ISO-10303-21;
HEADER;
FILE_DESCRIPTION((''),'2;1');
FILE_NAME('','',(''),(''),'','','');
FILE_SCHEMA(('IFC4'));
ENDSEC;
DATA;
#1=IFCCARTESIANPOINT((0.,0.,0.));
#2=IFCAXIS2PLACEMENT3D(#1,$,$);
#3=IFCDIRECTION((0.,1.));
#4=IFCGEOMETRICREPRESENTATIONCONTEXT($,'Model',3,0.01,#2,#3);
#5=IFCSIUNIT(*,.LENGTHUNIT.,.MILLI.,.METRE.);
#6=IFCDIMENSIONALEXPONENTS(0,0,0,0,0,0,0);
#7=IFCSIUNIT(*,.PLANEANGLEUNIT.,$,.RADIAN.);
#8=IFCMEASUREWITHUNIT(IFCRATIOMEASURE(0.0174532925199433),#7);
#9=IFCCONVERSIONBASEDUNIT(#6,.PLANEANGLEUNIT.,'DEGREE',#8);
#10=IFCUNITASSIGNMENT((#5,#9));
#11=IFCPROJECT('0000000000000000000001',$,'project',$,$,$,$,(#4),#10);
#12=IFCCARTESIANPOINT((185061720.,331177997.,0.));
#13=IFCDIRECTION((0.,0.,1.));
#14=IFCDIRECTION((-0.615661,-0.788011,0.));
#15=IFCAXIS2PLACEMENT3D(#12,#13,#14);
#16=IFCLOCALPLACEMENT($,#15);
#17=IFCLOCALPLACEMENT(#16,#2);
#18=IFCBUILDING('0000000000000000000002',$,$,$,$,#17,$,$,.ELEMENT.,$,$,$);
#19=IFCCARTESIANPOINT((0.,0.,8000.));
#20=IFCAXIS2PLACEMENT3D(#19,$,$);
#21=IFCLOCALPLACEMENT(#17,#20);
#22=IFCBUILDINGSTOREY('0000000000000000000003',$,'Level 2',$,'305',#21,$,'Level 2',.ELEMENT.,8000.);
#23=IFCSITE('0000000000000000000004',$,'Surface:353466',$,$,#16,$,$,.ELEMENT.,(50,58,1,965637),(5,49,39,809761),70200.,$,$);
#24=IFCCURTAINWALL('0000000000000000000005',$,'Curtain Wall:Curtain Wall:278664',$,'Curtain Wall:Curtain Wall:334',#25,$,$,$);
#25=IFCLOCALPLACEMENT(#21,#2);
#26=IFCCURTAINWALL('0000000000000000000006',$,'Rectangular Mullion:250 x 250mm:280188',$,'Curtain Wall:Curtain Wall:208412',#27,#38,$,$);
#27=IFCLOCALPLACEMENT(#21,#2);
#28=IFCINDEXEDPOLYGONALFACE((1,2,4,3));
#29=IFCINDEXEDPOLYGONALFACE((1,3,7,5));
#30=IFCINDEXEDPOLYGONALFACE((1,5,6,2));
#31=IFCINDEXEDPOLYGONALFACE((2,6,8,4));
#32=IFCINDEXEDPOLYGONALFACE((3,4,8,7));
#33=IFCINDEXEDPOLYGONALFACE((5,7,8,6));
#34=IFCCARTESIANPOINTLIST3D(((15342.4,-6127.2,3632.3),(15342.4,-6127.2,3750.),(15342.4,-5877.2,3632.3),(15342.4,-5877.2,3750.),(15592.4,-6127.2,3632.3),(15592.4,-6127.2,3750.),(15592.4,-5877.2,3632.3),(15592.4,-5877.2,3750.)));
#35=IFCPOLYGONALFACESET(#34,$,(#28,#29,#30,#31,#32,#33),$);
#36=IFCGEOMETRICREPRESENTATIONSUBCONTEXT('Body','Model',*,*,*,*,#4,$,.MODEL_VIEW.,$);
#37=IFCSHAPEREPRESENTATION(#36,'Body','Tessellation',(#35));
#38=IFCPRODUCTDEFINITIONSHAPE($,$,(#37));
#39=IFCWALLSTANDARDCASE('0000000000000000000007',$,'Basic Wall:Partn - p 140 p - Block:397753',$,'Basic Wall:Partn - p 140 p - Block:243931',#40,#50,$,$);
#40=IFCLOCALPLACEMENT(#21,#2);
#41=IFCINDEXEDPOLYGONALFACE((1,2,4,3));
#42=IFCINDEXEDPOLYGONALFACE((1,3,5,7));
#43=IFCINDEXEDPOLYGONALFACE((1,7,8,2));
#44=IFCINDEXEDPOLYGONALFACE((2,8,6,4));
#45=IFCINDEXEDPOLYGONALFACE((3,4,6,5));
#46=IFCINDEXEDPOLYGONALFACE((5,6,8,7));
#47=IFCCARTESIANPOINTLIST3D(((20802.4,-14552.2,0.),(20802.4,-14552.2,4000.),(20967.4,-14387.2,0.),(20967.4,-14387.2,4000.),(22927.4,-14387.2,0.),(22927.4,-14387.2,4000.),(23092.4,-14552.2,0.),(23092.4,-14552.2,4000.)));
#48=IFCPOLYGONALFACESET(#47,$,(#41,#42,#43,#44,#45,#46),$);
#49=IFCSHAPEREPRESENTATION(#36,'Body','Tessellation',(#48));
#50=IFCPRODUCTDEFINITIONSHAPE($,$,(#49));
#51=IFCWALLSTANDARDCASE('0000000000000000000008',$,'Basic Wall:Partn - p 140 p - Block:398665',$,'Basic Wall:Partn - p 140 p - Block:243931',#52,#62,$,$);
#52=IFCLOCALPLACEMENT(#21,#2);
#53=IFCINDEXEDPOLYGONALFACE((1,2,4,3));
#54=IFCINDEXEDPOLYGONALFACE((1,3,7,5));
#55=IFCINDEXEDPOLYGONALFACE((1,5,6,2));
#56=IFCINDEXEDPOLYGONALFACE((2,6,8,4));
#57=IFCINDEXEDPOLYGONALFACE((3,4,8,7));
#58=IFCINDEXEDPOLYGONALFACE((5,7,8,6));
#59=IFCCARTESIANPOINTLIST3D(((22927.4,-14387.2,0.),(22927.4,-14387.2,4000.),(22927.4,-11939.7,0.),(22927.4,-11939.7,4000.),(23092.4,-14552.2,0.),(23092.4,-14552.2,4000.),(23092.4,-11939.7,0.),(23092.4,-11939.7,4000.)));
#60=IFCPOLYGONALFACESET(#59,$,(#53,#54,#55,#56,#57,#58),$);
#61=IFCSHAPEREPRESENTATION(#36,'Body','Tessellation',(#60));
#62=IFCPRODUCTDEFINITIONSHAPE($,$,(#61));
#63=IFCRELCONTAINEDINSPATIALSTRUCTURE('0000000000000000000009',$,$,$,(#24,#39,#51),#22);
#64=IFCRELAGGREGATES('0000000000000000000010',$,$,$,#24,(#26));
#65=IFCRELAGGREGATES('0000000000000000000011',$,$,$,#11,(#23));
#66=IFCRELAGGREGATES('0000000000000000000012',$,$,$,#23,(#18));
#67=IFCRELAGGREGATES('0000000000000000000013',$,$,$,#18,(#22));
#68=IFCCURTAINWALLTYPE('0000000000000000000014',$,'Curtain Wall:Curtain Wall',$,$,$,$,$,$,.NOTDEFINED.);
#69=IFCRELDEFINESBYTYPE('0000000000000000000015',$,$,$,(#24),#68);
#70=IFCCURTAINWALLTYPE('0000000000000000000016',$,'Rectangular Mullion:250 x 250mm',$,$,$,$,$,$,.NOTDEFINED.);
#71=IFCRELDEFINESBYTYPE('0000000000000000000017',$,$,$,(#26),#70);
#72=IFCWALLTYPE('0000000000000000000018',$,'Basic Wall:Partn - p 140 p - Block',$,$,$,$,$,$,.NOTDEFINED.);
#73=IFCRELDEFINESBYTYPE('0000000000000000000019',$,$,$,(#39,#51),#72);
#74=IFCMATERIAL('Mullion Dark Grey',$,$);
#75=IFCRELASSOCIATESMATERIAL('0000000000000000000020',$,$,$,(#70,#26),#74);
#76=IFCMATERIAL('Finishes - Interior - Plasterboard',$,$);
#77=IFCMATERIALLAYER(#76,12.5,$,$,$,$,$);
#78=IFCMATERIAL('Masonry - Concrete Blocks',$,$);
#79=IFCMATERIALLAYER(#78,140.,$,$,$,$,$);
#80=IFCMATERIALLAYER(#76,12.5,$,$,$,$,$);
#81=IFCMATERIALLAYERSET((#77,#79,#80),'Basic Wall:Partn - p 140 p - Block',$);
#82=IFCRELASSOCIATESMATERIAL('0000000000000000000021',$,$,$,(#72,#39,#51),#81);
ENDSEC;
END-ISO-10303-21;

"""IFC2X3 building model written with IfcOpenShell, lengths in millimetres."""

from ifc_helpers import new_model, entity, si_unit, converted_unit, direction, frame, origin, origin_2d_with_axis, place, context, subcontext, project, spatial, polyline, rectangle, outline, extrude, clip, halfspace, source, transform, mapped, material, layer, layer_set, layer_usage, type_object, type_shapes, element, aggregate, save


model = new_model("IFC2X3")

# Units and contexts
model_context = context("Model", 3, precision=0.01, world=origin(), true_north=direction((0.0, 1.0)))
body_context = subcontext(model_context, "Body", "Model", "MODEL_VIEW")
ifc_project = project(units=[si_unit("LENGTHUNIT", "METRE", prefix="MILLI"), converted_unit("PLANEANGLEUNIT", "DEGREE", entity("IfcRatioMeasure", 0.0174532925199433), si_unit("PLANEANGLEUNIT", "RADIAN"), dimensions=[0, 0, 0, 0, 0, 0, 0])], contexts=[model_context])

# Site, building, storey
site_placement = place(None, frame((185061720.0, 331177997.0, 0.0), z_axis=(0.0, 0.0, 1.0), x_axis=(-0.615661, -0.788011, 0.0)))
site = spatial("IfcSite", under=ifc_project, at=site_placement, Name="Surface:353466", CompositionType="ELEMENT", RefLatitude=(50, 58, 1, 965637), RefLongitude=(5, 49, 39, 809761), RefElevation=70200.0)
building_placement = place(site_placement, origin())
building = spatial("IfcBuilding", under=site, at=building_placement, CompositionType="ELEMENT")
storey_placement = place(building_placement, frame((0.0, 0.0, 8000.0)))
storey = spatial("IfcBuildingStorey", under=building, at=storey_placement, Name="Level 2", ObjectType="305", LongName="Level 2", CompositionType="ELEMENT", Elevation=8000.0)

# Shared definitions
ifc_material_1 = material(Name="Masonry - Concrete Blocks")
ifc_material_2 = material(Name="Finishes - Interior - Plasterboard")

# Curtain walls
curtain_wall_type_1 = type_object("IfcCurtainWallType", Name="Curtain Wall:Curtain Wall", PredefinedType="NOTDEFINED")
curtain_wall_1_placement = place(storey_placement, frame((0.0, 0.0, -8000.0)))
curtain_wall_1 = element("IfcCurtainWall", 1, at=curtain_wall_1_placement, inside=storey, type_object=curtain_wall_type_1, Name="Curtain Wall:Curtain Wall:278664", ObjectType="Curtain Wall:Curtain Wall:334")
ifc_material_3 = material(Name="Mullion Dark Grey")
curtain_wall_type_2 = type_object("IfcCurtainWallType", Name="Rectangular Mullion:250 x 250mm", PredefinedType="NOTDEFINED", material=ifc_material_3)
shared_shape_1 = source(origin(), body_context, "Body", "SweptSolid", [
    extrude(rectangle(XDim=250.0, YDim=250.0, at=origin_2d_with_axis()), frame((-125.0, 0.0, -117.7), z_axis=(0.0, 0.0, 1.0), x_axis=(-1.0, 0.0, 0.0)), (0.0, 0.0, 1.0), 117.7),
])
type_shapes(curtain_wall_type_2, [shared_shape_1])
curtain_wall_2_placement = place(storey_placement, frame((15592.4, -6002.2, 3632.3), z_axis=(0.0, 0.0, -1.0), x_axis=(1.0, 0.0, 0.0)))
curtain_wall_2 = element("IfcCurtainWall", 2, at=curtain_wall_2_placement, type_object=curtain_wall_type_2, material=ifc_material_3, Name="Rectangular Mullion:250 x 250mm:280188", ObjectType="Curtain Wall:Curtain Wall:208412", context=body_context, shape_type="MappedRepresentation", body=[
    mapped(shared_shape_1, transform((0.0, 0.0, 0.0), scale=1.0)),
])
aggregate(curtain_wall_1, [curtain_wall_2])

# Walls
ifc_layer_1 = layer(ifc_material_2, 12.5)
ifc_layer_2 = layer(ifc_material_1, 140.0)
ifc_layer_3 = layer(ifc_material_2, 12.5)
ifc_layer_set_1 = layer_set([ifc_layer_1, ifc_layer_2, ifc_layer_3], Name="Basic Wall:Partn - p 140 p - Block")
ifc_layer_usage_1 = layer_usage(ifc_layer_set_1, "AXIS2", "NEGATIVE", 82.5)
wall_type_1 = type_object("IfcWallType", Name="Basic Wall:Partn - p 140 p - Block", PredefinedType="NOTDEFINED", material=ifc_layer_set_1)
wall_1_placement = place(storey_placement, frame((23092.4, -14469.7, 0.0), z_axis=(0.0, 0.0, 1.0), x_axis=(-1.0, 0.0, 0.0)))
element("IfcWallStandardCase", 3, at=wall_1_placement, inside=storey, type_object=wall_type_1, material=ifc_layer_usage_1, Name="Basic Wall:Partn - p 140 p - Block:397753", ObjectType="Basic Wall:Partn - p 140 p - Block:243931", context=body_context, shape_type="Clipping", body=[
    clip(extrude(outline(polyline([(2125.0, -82.5), (2290.0, 82.5), (0.0, 82.5), (165.0, -82.5), (2125.0, -82.5)])), origin(), (0.0, 0.0, 1.0), 4000.0), halfspace(frame((0.0, 0.0, -8000.0)), True)),
])
ifc_layer_usage_2 = layer_usage(ifc_layer_set_1, "AXIS2", "NEGATIVE", 82.5)
wall_2_placement = place(storey_placement, frame((23009.9, -14552.2, 0.0), z_axis=(0.0, 0.0, 1.0), x_axis=(0.0, 1.0, 0.0)))
element("IfcWallStandardCase", 4, at=wall_2_placement, inside=storey, type_object=wall_type_1, material=ifc_layer_usage_2, Name="Basic Wall:Partn - p 140 p - Block:398665", ObjectType="Basic Wall:Partn - p 140 p - Block:243931", context=body_context, shape_type="Clipping", body=[
    clip(extrude(outline(polyline([(2612.5, -82.5), (2612.5, 82.5), (165.0, 82.5), (0.0, -82.5), (2612.5, -82.5)])), origin(), (0.0, 0.0, 1.0), 4000.0), halfspace(frame((0.0, 0.0, -8000.0)), True)),
])

save(model, "model.ifc")
